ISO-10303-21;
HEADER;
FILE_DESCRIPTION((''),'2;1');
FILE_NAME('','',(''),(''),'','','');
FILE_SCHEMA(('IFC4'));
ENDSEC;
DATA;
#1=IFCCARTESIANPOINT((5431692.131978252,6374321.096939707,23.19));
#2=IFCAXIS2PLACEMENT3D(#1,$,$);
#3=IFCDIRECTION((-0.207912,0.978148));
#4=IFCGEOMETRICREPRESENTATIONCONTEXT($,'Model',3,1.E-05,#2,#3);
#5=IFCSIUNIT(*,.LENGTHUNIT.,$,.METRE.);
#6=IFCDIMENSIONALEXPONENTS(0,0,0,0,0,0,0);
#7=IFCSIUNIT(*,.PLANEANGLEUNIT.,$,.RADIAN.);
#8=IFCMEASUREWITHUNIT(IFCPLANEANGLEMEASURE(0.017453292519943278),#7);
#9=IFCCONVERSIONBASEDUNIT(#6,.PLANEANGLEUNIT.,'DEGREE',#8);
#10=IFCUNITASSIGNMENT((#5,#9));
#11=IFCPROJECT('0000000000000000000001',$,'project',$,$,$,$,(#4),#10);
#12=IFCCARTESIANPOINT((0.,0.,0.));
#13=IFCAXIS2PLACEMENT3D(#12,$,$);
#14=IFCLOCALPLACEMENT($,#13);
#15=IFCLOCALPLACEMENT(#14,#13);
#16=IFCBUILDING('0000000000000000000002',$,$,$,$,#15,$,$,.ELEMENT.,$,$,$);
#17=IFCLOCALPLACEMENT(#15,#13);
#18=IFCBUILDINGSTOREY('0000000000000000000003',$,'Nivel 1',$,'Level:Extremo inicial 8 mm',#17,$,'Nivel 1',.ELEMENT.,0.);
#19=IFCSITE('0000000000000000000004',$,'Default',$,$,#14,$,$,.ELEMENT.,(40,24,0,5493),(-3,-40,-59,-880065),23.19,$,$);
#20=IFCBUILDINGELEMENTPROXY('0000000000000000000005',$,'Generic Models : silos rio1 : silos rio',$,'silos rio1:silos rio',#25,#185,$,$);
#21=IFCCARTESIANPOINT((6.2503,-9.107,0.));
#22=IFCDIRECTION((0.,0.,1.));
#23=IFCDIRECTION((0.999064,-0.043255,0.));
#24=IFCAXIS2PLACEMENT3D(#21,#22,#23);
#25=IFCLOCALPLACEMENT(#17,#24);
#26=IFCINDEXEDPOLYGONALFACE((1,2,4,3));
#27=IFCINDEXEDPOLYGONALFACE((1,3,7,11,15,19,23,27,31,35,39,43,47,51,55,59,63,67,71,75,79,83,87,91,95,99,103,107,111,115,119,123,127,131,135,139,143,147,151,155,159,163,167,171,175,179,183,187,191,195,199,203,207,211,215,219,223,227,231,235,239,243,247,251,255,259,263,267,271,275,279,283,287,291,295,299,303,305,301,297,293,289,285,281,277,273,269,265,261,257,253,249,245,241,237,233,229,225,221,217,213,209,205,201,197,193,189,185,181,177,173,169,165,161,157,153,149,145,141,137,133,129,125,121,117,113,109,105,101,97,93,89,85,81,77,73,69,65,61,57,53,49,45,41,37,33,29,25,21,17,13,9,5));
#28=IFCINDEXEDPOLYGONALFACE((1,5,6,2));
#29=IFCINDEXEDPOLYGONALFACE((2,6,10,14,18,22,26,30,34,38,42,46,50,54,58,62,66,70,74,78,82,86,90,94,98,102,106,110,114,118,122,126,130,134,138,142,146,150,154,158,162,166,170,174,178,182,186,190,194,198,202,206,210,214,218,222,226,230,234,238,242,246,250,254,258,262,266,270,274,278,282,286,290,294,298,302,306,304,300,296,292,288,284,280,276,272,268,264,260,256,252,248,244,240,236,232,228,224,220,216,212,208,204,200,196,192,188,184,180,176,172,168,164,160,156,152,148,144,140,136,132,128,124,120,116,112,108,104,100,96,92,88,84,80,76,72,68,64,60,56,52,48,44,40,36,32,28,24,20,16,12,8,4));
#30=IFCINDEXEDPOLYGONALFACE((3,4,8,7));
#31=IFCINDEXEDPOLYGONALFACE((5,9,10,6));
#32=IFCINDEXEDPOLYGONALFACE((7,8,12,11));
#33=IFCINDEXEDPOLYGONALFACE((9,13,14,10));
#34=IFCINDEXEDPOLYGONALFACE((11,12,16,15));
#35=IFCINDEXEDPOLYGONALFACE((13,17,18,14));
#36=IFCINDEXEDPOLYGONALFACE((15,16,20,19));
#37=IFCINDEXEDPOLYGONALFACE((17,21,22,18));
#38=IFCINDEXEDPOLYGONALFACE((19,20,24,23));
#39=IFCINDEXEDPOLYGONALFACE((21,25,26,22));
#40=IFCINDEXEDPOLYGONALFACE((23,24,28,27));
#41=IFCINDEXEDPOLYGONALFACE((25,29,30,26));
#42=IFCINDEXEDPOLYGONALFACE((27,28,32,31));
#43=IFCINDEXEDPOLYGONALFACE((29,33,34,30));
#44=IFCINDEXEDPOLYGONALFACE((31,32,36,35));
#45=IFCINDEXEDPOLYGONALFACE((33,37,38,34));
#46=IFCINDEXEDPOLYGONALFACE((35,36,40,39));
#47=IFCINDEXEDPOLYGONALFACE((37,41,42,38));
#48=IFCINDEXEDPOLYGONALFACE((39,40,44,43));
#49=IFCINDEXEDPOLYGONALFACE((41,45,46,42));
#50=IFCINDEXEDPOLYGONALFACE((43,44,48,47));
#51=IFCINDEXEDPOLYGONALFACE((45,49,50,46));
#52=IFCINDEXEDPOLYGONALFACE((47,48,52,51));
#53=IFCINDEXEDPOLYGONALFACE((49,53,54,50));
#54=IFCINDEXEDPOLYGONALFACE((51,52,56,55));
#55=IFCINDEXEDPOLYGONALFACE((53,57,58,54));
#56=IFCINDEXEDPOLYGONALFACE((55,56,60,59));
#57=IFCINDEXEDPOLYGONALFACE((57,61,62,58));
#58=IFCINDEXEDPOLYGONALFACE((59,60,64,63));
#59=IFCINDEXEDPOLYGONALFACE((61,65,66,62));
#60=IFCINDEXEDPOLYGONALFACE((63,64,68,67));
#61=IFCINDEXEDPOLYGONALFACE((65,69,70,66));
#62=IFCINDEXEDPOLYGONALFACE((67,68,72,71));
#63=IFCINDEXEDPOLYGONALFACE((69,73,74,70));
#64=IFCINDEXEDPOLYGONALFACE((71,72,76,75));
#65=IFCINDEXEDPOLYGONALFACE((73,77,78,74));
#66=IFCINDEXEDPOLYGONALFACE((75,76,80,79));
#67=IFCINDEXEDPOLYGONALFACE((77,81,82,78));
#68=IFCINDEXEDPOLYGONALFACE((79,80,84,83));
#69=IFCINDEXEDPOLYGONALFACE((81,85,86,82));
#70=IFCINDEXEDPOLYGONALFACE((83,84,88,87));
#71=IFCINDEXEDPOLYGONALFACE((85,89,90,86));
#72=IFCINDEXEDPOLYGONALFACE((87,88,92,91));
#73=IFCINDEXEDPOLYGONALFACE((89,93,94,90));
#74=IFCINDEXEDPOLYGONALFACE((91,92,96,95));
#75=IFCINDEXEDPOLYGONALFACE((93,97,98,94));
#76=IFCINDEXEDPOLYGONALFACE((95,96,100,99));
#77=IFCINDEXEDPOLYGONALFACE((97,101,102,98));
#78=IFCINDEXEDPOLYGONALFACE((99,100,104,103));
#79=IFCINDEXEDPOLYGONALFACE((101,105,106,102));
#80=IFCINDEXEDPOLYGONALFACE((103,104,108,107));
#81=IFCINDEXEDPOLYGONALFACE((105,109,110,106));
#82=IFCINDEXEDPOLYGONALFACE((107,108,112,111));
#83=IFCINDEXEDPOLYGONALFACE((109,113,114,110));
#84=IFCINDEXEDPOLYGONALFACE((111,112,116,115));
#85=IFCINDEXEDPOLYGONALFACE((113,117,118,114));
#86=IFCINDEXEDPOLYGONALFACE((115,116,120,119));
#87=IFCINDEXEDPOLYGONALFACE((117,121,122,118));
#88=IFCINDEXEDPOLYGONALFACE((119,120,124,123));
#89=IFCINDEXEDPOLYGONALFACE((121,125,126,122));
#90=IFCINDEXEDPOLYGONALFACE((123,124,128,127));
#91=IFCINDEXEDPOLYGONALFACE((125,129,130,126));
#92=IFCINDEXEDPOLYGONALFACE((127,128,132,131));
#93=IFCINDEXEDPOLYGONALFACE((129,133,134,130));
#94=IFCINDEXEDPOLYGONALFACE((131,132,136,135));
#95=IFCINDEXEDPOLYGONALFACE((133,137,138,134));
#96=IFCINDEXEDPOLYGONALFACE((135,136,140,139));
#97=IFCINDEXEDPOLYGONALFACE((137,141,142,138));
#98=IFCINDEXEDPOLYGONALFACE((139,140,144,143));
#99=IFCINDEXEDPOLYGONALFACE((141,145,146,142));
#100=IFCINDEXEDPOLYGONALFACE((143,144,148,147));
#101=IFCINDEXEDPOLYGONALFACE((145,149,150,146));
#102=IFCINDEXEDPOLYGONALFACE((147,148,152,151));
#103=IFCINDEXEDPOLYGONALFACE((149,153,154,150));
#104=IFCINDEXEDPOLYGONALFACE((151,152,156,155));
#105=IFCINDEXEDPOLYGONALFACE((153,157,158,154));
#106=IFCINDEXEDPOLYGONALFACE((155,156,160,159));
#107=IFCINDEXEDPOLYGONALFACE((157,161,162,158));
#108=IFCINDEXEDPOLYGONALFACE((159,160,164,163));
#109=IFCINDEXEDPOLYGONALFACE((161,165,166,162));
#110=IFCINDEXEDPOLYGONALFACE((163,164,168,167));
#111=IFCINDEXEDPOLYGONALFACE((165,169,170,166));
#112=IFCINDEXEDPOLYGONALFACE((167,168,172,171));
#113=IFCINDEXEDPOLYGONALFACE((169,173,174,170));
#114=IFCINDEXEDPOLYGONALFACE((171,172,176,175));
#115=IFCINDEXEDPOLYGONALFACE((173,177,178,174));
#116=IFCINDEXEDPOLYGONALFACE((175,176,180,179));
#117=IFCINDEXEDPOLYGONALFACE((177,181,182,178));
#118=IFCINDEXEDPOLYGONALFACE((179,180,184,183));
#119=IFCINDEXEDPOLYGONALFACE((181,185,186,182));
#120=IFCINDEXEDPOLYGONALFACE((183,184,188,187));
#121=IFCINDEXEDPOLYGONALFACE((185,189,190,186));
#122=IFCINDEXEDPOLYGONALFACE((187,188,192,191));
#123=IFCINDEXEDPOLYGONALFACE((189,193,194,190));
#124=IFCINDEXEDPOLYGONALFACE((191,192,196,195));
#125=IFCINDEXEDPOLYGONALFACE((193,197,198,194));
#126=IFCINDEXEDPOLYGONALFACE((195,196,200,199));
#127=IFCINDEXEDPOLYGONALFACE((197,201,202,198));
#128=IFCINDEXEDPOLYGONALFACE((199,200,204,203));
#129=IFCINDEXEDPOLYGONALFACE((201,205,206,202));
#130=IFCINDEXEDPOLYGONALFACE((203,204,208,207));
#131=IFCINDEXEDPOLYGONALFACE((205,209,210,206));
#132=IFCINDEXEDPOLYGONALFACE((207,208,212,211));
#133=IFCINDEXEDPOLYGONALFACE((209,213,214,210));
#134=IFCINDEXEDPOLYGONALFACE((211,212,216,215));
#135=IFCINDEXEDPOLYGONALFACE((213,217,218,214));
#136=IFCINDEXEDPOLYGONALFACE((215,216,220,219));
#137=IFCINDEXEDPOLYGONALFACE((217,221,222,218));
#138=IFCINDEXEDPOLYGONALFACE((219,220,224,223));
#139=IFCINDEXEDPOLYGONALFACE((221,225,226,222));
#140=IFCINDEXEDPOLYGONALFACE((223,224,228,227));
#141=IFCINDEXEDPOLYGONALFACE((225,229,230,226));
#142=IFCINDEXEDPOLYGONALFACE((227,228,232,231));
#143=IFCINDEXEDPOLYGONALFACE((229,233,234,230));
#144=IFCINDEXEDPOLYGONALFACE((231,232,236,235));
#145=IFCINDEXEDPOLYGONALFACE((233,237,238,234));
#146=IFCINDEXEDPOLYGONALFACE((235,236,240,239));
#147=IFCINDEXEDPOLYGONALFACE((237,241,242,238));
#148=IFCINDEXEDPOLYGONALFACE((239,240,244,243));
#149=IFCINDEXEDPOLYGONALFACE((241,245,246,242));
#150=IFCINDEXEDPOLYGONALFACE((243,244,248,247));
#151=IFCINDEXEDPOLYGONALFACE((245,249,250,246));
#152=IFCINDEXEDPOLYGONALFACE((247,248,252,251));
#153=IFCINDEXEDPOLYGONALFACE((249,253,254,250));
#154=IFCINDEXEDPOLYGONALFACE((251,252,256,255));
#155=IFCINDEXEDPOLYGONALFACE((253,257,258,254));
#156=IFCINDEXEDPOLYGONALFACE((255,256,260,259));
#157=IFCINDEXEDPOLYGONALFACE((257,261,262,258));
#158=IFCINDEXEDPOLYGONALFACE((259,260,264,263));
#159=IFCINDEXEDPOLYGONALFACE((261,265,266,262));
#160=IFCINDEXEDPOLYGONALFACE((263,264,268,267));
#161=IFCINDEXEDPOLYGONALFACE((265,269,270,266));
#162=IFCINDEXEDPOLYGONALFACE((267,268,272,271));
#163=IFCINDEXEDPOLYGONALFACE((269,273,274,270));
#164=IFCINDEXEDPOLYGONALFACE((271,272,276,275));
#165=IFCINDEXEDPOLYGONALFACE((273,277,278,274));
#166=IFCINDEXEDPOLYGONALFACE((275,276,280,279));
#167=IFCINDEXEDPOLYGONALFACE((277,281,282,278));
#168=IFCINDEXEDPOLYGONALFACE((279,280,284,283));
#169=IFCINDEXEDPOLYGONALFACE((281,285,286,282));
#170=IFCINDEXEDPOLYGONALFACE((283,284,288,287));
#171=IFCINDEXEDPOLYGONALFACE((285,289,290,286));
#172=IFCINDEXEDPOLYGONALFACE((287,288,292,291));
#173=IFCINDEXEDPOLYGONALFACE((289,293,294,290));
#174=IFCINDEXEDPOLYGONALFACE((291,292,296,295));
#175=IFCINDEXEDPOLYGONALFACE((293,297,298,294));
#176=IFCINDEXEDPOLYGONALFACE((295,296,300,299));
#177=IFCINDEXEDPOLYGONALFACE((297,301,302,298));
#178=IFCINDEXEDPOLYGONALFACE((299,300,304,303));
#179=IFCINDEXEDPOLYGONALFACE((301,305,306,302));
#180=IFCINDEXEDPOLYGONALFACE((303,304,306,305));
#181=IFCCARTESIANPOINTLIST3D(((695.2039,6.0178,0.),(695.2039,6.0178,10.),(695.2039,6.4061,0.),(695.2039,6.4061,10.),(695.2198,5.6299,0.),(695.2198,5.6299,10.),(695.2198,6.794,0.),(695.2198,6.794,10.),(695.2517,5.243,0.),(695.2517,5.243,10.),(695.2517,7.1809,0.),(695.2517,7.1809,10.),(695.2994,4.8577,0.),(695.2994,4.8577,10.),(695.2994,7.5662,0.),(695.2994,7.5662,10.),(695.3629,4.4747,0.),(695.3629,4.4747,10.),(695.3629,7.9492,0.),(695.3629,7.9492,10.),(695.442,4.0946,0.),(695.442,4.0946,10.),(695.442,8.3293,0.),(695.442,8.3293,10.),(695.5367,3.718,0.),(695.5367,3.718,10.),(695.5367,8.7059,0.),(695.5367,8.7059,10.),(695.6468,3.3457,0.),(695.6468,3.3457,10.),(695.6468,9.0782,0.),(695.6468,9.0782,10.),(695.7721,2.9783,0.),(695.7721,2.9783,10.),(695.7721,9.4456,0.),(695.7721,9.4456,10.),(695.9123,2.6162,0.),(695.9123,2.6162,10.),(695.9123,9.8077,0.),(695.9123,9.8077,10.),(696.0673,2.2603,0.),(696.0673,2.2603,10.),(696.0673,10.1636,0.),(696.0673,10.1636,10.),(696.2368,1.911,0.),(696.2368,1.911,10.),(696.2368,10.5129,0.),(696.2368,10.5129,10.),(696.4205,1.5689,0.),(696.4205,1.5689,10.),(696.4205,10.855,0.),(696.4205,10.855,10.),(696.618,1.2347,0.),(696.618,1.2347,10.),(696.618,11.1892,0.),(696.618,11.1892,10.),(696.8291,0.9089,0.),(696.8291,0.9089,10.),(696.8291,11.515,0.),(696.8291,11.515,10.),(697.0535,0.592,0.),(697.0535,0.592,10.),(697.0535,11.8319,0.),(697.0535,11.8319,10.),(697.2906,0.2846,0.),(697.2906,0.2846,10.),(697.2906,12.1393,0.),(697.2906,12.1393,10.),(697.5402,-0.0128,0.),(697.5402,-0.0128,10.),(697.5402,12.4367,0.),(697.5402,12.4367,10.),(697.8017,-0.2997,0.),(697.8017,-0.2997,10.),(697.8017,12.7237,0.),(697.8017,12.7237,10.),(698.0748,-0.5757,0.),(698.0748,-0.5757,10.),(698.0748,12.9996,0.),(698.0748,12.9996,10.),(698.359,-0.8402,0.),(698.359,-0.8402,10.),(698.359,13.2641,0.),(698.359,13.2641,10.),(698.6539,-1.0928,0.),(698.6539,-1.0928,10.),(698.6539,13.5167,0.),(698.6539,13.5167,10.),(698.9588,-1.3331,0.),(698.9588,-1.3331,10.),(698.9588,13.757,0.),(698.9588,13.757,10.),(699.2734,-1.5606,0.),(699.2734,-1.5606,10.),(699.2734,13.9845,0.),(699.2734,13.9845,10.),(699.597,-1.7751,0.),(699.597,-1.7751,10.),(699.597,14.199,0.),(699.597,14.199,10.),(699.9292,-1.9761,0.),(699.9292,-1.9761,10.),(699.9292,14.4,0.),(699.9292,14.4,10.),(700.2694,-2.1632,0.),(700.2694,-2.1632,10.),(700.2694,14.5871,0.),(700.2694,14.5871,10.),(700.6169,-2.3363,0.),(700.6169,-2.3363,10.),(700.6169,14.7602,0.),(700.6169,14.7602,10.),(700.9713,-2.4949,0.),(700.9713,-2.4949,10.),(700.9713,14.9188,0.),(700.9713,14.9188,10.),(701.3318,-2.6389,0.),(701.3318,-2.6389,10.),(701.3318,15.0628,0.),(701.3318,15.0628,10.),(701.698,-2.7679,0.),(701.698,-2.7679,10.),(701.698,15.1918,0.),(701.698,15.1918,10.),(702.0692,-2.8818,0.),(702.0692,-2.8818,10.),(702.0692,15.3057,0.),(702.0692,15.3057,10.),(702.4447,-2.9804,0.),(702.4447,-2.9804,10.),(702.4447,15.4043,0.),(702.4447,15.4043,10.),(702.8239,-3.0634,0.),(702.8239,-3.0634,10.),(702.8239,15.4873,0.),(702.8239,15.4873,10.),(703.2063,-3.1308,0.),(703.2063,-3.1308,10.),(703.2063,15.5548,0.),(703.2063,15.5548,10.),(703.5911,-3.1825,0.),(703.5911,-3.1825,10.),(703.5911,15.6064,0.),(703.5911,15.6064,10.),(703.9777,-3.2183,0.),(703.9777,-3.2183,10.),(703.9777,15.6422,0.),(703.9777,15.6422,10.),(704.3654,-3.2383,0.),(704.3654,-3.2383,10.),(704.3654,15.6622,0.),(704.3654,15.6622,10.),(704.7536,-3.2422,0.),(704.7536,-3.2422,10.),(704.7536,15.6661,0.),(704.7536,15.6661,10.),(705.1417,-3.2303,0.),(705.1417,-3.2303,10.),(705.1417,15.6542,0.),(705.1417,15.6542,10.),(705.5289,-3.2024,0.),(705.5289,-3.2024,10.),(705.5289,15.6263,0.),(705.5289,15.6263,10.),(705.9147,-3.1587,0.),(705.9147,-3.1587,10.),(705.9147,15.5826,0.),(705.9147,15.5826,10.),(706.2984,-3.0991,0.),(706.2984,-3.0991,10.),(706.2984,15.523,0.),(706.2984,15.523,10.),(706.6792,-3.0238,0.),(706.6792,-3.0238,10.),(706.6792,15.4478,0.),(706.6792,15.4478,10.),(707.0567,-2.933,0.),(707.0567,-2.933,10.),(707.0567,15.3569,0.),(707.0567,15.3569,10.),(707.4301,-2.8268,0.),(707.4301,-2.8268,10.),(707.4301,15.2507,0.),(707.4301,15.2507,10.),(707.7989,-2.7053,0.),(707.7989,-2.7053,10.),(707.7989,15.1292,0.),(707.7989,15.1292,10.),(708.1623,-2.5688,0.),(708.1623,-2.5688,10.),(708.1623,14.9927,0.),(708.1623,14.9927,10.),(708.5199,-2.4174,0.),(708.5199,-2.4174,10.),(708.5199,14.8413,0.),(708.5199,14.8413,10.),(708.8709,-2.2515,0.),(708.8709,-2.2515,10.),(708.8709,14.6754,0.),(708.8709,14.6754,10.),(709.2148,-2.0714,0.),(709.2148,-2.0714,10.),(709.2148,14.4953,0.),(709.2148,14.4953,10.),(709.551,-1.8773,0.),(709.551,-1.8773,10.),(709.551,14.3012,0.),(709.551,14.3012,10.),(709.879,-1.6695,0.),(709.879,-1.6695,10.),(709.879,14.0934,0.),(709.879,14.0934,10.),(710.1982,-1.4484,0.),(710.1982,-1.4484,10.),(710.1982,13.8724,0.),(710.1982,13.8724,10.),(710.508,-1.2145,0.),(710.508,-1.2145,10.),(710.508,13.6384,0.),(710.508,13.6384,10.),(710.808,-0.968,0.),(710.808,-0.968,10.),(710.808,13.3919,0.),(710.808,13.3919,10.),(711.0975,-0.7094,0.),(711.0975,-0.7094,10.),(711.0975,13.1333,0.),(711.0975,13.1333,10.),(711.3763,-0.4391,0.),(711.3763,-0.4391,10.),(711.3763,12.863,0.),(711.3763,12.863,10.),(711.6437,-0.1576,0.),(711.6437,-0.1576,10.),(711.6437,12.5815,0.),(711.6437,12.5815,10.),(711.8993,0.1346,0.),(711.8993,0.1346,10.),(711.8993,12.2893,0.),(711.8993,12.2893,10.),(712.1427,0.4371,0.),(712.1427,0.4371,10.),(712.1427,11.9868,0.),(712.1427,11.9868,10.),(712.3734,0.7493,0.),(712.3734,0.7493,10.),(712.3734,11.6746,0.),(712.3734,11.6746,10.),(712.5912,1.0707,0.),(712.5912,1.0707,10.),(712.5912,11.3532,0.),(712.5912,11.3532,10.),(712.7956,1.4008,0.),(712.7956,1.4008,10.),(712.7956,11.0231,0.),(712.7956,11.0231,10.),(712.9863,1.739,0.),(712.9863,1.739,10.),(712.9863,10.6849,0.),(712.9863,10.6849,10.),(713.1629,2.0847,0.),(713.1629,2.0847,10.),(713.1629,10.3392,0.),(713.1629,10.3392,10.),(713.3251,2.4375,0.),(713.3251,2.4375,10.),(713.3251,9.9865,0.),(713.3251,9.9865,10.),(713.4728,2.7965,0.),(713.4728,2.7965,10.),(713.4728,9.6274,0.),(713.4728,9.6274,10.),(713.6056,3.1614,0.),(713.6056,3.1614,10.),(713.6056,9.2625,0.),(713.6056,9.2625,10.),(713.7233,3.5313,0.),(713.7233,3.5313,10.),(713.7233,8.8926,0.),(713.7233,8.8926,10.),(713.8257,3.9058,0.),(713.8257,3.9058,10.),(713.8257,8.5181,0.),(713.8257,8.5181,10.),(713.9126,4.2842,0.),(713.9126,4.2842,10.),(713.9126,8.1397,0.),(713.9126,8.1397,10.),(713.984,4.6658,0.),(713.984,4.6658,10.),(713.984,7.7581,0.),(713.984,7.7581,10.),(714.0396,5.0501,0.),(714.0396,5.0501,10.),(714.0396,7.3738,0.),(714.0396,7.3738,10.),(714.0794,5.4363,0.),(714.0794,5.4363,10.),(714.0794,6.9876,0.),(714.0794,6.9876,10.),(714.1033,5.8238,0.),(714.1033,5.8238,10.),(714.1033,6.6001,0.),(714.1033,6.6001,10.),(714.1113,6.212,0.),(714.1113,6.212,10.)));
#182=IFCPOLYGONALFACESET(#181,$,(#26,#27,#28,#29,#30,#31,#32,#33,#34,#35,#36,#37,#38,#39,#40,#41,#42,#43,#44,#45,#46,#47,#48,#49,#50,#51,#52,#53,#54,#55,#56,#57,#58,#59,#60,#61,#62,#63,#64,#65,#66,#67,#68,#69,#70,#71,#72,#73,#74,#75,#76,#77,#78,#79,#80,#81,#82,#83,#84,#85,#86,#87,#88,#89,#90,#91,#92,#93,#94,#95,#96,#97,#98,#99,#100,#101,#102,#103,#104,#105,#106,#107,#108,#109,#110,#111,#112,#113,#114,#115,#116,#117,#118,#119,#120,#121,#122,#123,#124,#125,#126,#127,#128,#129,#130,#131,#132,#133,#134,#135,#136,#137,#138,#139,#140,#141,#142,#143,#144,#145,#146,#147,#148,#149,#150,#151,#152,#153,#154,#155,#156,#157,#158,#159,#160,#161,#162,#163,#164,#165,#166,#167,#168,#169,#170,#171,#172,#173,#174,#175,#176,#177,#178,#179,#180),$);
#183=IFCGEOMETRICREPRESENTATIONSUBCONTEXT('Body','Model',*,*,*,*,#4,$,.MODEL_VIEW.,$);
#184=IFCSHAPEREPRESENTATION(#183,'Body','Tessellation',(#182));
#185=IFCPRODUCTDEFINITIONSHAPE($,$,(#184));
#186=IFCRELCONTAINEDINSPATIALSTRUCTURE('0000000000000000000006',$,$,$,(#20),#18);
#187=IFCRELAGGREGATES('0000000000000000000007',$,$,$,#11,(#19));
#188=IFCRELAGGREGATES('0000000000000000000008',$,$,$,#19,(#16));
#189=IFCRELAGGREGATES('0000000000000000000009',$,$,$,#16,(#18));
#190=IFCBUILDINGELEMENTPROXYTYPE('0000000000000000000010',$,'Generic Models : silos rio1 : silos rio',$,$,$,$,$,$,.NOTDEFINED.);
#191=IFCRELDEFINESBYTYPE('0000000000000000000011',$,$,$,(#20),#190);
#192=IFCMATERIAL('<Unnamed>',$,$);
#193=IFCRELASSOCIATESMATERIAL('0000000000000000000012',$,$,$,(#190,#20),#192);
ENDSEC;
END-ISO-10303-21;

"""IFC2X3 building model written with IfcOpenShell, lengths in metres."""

from ifc_helpers import new_model, entity, si_unit, converted_unit, direction, frame, frame_2d, origin, place, context, subcontext, project, spatial, circle, extrude, source, transform, mapped, material, type_object, type_shapes, element, save


model = new_model("IFC2X3")

# Units and contexts
model_context = context("Model", 3, precision=1e-05, world=frame((5431692.131978252, 6374321.096939707, 23.19)), true_north=direction((-0.207912, 0.978148)))
body_context = subcontext(model_context, "Body", "Model", "MODEL_VIEW")
ifc_project = project(units=[si_unit("LENGTHUNIT", "METRE"), converted_unit("PLANEANGLEUNIT", "DEGREE", entity("IfcPlaneAngleMeasure", 0.017453292519943278), si_unit("PLANEANGLEUNIT", "RADIAN"), dimensions=[0, 0, 0, 0, 0, 0, 0])], contexts=[model_context])

# Site, building, storey
site_placement = place(None, origin())
site = spatial("IfcSite", under=ifc_project, at=site_placement, Name="Default", CompositionType="ELEMENT", RefLatitude=(40, 24, 0, 5493), RefLongitude=(-3, -40, -59, -880065), RefElevation=23.19)
building_placement = place(site_placement, origin())
building = spatial("IfcBuilding", under=site, at=building_placement, CompositionType="ELEMENT")
storey_placement = place(building_placement, origin())
storey = spatial("IfcBuildingStorey", under=building, at=storey_placement, Name="Nivel 1", ObjectType="Level:Extremo inicial 8 mm", LongName="Nivel 1", CompositionType="ELEMENT", Elevation=0.0)

# Building element proxy
ifc_material_1 = material(Name="<Unnamed>")
building_element_proxy_type_1 = type_object("IfcBuildingElementProxyType", Name="Generic Models : silos rio1 : silos rio", PredefinedType="NOTDEFINED", material=ifc_material_1)
shared_shape_1 = source(origin(), body_context, "Body", "SweptSolid", [
    extrude(circle(Radius=9.4547, at=frame_2d((0.0, 0.0), x_axis=(1.0, 0.0))), frame((704.6566, 6.212, 0.0)), (0.0, 0.0, 1.0), 10.0),
])
type_shapes(building_element_proxy_type_1, [shared_shape_1])
proxy_1_placement = place(storey_placement, frame((6.2503, -9.107, 0.0), z_axis=(0.0, 0.0, 1.0), x_axis=(0.999064, -0.043255, 0.0)))
element("IfcBuildingElementProxy", 1, at=proxy_1_placement, inside=storey, type_object=building_element_proxy_type_1, material=ifc_material_1, Name="Generic Models : silos rio1 : silos rio", ObjectType="silos rio1:silos rio", context=body_context, shape_type="MappedRepresentation", body=[
    mapped(shared_shape_1, transform((0.0, 0.0, 0.0), scale=1.0)),
])

save(model, "model.ifc")
